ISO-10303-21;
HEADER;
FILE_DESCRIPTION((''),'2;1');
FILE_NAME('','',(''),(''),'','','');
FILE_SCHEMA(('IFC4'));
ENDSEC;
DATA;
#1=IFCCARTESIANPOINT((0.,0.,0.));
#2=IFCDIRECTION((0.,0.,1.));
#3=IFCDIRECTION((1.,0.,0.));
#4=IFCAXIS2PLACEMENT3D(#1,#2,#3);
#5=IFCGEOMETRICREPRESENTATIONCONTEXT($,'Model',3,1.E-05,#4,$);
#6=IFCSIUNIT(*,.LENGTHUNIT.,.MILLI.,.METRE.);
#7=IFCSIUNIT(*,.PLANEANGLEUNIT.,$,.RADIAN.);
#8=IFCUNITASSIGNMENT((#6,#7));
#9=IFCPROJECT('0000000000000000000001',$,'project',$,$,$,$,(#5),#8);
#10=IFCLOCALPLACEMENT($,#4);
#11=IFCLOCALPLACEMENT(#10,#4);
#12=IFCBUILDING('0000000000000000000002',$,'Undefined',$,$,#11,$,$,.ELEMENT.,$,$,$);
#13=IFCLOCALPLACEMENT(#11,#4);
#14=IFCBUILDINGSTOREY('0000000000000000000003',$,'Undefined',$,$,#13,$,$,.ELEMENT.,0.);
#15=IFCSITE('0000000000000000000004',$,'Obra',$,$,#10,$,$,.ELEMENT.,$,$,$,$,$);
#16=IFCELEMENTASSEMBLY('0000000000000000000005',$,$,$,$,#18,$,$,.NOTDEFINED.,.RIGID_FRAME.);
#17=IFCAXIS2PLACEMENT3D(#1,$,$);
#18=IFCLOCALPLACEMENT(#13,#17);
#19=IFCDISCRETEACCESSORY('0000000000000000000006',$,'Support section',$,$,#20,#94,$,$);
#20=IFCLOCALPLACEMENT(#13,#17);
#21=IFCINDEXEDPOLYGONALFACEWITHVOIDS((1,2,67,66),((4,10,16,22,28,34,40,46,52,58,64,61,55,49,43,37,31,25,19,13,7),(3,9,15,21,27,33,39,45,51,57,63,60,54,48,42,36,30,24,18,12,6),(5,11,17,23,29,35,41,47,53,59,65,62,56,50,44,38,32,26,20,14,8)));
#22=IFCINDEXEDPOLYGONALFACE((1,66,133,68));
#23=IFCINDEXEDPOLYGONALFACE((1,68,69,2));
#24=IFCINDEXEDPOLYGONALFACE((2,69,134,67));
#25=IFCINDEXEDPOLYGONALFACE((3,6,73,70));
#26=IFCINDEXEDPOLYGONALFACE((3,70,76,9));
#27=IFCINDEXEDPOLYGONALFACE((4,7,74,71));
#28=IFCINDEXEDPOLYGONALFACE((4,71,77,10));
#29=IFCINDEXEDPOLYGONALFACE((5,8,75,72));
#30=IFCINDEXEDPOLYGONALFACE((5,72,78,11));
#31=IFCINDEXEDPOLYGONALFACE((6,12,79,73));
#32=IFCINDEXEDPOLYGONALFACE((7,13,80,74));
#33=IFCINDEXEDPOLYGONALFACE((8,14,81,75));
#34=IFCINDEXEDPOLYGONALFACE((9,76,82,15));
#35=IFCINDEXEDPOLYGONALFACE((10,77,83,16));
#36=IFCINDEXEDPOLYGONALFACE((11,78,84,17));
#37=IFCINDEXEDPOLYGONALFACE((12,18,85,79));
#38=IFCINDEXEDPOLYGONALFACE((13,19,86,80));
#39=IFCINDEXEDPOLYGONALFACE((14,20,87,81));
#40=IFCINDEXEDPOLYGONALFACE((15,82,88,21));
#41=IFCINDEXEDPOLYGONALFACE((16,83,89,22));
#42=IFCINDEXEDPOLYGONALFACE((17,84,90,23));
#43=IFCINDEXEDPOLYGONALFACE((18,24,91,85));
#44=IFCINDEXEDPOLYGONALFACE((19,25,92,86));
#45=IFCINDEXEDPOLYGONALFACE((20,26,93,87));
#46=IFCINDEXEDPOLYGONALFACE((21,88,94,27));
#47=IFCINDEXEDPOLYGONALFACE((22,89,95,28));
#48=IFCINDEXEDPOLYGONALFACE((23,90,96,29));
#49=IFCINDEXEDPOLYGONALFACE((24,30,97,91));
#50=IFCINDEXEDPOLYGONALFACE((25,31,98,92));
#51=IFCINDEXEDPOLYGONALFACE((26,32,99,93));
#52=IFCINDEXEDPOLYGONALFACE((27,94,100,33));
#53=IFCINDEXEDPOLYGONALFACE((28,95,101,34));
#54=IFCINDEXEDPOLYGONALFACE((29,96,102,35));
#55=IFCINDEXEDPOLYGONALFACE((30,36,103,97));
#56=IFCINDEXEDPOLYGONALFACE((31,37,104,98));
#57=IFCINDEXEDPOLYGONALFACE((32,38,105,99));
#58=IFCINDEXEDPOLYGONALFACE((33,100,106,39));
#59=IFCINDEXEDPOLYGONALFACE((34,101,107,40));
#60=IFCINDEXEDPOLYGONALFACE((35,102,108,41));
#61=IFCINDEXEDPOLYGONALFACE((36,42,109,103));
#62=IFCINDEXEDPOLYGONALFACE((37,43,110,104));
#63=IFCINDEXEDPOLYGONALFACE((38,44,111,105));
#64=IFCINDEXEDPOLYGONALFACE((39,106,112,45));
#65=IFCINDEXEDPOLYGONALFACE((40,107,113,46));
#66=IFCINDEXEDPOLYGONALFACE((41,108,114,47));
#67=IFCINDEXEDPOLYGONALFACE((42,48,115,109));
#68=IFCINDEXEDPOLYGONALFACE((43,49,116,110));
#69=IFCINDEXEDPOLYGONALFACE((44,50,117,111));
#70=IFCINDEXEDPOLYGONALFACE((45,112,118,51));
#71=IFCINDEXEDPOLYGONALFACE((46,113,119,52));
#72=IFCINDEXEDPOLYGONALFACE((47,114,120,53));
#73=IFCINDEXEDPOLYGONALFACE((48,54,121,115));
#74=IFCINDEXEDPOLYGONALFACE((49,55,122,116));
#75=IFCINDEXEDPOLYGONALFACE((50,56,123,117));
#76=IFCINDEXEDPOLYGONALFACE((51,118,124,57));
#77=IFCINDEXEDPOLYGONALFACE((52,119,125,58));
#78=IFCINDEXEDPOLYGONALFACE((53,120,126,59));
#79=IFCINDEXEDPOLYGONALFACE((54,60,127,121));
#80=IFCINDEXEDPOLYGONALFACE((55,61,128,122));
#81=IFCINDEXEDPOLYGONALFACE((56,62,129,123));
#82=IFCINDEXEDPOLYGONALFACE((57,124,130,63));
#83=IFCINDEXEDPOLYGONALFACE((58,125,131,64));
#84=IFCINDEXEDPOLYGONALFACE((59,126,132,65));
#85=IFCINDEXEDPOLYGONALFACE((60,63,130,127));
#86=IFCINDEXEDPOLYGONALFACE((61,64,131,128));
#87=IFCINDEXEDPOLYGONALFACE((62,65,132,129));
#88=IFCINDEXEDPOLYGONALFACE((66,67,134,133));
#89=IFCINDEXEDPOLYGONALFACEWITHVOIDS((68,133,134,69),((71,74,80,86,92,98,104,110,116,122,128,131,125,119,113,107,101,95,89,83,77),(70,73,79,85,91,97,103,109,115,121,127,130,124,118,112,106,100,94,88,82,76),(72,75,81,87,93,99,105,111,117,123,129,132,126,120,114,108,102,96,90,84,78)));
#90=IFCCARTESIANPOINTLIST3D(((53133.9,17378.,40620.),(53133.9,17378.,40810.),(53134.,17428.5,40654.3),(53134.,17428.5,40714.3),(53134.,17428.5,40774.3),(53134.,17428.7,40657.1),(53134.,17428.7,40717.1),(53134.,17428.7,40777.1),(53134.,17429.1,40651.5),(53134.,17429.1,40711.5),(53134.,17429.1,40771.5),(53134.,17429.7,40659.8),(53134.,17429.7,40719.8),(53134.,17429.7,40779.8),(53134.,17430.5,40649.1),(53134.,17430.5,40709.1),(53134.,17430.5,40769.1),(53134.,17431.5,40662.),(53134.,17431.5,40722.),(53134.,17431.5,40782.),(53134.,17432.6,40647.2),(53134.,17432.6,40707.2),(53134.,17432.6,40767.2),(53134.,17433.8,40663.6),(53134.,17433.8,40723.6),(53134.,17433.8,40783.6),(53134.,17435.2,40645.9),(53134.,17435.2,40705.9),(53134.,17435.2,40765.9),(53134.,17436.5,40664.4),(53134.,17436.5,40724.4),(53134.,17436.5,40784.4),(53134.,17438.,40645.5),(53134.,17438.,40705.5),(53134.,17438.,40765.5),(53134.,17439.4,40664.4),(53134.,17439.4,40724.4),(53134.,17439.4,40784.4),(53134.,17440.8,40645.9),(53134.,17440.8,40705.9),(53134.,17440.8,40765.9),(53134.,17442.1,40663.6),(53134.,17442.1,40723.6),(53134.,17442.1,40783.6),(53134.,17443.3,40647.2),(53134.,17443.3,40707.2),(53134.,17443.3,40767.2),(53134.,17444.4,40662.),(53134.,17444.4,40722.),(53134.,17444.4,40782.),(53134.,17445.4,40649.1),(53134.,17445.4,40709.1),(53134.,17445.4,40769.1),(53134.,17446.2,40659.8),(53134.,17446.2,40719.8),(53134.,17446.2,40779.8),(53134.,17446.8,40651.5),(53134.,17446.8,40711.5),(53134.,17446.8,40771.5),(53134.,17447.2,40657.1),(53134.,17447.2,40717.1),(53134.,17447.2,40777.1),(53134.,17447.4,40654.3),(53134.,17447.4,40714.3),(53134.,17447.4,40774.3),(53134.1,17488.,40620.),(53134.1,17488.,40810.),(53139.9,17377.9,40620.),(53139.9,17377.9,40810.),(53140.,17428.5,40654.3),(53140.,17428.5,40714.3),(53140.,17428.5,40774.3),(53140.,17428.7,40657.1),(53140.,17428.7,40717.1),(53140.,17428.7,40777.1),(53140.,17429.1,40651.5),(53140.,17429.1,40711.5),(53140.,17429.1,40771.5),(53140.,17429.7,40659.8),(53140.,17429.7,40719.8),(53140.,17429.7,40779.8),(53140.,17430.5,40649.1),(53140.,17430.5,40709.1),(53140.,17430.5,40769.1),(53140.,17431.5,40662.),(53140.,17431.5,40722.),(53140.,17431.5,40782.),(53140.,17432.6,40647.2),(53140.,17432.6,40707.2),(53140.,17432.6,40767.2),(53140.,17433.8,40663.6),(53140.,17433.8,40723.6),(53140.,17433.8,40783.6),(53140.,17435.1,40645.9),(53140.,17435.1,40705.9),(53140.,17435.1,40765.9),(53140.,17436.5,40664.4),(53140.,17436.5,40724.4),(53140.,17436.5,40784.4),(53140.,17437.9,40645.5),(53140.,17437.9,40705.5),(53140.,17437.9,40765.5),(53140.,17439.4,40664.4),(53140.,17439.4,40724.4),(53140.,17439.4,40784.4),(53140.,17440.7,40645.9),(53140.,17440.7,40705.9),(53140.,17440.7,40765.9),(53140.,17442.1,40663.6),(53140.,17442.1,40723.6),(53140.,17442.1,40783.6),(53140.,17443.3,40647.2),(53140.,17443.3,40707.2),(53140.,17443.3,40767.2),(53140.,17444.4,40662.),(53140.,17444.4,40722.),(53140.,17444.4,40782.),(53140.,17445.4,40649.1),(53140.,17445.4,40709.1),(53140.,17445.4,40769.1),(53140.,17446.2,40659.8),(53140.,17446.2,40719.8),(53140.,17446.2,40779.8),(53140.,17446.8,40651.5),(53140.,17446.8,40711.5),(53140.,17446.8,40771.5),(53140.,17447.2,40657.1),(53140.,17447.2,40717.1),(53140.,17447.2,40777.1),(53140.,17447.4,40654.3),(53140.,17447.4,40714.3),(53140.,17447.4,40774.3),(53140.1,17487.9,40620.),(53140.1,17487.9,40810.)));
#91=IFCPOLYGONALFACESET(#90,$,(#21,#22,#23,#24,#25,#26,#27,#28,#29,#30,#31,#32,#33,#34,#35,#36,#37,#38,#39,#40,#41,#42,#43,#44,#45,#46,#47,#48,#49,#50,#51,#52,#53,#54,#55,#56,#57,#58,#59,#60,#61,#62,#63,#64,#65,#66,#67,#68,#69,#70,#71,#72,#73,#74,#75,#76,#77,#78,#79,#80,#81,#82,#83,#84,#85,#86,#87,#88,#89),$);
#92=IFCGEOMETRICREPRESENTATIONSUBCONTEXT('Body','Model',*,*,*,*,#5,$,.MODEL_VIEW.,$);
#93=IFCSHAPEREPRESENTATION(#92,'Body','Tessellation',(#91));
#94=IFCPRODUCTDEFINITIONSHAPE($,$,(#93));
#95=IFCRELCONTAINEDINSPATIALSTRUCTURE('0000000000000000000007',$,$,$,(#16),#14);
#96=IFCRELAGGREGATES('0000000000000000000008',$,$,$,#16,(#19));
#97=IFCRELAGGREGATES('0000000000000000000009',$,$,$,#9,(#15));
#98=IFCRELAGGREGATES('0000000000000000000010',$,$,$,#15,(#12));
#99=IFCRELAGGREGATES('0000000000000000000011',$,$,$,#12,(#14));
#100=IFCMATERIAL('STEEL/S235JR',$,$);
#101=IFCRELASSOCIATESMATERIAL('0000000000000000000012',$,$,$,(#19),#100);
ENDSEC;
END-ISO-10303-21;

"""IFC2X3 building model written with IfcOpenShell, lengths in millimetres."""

from ifc_helpers import new_model, si_unit, frame, origin_with_axes, origin_2d_with_axis, place, context, subcontext, project, spatial, rectangle, circle, extrude, source, transform, mapped, material, element, aggregate, save


model = new_model("IFC2X3")

# Units and contexts
model_context = context("Model", 3, precision=1e-05, world=origin_with_axes())
body_context = subcontext(model_context, "Body", "Model", "MODEL_VIEW")
ifc_project = project(units=[si_unit("LENGTHUNIT", "METRE", prefix="MILLI"), si_unit("PLANEANGLEUNIT", "RADIAN")], contexts=[model_context])

# Site, building, storey
site_placement = place(None, origin_with_axes())
site = spatial("IfcSite", under=ifc_project, at=site_placement, Name="Obra", CompositionType="ELEMENT")
building_placement = place(site_placement, origin_with_axes())
building = spatial("IfcBuilding", under=site, at=building_placement, Name="Undefined", CompositionType="ELEMENT")
storey_placement = place(building_placement, origin_with_axes())
storey = spatial("IfcBuildingStorey", under=building, at=storey_placement, Name="Undefined", CompositionType="ELEMENT", Elevation=0.0)

# Element assembly
ifc_material_1 = material(Name="STEEL/S235JR")
assembly_1_placement = place(storey_placement, origin_with_axes())
assembly_1 = element("IfcElementAssembly", 1, at=assembly_1_placement, inside=storey, AssemblyPlace="NOTDEFINED", PredefinedType="RIGID_FRAME")

# Discrete accessory, opening
shared_shape_1 = source(origin_with_axes(), body_context, "Body", "SweptSolid", [
    extrude(circle(Radius=9.5, at=origin_2d_with_axis()), frame((0.0, -9.2, 0.0), z_axis=(0.0, 1.0, 0.0), x_axis=(1.0, 0.0, 0.0)), (0.0, 0.0, 1.0), 6.2),
])
discrete_accessory_1_placement = place(assembly_1_placement, frame((53137.0, 17433.0, 40620.0), z_axis=(0.0, 0.0, 1.0), x_axis=(-0.001649, -0.999999, 0.0)))
discrete_accessory_1 = element("IfcDiscreteAccessory", 2, at=discrete_accessory_1_placement, material=ifc_material_1, Name="Support section", context=body_context, shape_type="SweptSolid", body=[
    extrude(rectangle(XDim=6.0, YDim=110.0, at=origin_2d_with_axis()), frame((0.0, 0.0, 190.0), z_axis=(0.0, 0.0, -1.0), x_axis=(0.0, 1.0, 0.0)), (0.0, 0.0, 1.0), 190.0),
])
opening_1_placement = place(assembly_1_placement, frame((53130.8, 17388.0, 40835.0), z_axis=(0.001649, 0.999999, 0.0), x_axis=(0.0, 0.0, -1.0)))
element("IfcOpeningElement", 3, at=opening_1_placement, cuts=discrete_accessory_1, ObjectType="Opening", context=body_context, shape_type="MappedRepresentation", body=[
    mapped(shared_shape_1, transform((60.0, 0.0, 50.0))),
    mapped(shared_shape_1, transform((120.0, 0.0, 50.0))),
    mapped(shared_shape_1, transform((180.0, 0.0, 50.0))),
])
aggregate(assembly_1, [discrete_accessory_1])

save(model, "model.ifc")
